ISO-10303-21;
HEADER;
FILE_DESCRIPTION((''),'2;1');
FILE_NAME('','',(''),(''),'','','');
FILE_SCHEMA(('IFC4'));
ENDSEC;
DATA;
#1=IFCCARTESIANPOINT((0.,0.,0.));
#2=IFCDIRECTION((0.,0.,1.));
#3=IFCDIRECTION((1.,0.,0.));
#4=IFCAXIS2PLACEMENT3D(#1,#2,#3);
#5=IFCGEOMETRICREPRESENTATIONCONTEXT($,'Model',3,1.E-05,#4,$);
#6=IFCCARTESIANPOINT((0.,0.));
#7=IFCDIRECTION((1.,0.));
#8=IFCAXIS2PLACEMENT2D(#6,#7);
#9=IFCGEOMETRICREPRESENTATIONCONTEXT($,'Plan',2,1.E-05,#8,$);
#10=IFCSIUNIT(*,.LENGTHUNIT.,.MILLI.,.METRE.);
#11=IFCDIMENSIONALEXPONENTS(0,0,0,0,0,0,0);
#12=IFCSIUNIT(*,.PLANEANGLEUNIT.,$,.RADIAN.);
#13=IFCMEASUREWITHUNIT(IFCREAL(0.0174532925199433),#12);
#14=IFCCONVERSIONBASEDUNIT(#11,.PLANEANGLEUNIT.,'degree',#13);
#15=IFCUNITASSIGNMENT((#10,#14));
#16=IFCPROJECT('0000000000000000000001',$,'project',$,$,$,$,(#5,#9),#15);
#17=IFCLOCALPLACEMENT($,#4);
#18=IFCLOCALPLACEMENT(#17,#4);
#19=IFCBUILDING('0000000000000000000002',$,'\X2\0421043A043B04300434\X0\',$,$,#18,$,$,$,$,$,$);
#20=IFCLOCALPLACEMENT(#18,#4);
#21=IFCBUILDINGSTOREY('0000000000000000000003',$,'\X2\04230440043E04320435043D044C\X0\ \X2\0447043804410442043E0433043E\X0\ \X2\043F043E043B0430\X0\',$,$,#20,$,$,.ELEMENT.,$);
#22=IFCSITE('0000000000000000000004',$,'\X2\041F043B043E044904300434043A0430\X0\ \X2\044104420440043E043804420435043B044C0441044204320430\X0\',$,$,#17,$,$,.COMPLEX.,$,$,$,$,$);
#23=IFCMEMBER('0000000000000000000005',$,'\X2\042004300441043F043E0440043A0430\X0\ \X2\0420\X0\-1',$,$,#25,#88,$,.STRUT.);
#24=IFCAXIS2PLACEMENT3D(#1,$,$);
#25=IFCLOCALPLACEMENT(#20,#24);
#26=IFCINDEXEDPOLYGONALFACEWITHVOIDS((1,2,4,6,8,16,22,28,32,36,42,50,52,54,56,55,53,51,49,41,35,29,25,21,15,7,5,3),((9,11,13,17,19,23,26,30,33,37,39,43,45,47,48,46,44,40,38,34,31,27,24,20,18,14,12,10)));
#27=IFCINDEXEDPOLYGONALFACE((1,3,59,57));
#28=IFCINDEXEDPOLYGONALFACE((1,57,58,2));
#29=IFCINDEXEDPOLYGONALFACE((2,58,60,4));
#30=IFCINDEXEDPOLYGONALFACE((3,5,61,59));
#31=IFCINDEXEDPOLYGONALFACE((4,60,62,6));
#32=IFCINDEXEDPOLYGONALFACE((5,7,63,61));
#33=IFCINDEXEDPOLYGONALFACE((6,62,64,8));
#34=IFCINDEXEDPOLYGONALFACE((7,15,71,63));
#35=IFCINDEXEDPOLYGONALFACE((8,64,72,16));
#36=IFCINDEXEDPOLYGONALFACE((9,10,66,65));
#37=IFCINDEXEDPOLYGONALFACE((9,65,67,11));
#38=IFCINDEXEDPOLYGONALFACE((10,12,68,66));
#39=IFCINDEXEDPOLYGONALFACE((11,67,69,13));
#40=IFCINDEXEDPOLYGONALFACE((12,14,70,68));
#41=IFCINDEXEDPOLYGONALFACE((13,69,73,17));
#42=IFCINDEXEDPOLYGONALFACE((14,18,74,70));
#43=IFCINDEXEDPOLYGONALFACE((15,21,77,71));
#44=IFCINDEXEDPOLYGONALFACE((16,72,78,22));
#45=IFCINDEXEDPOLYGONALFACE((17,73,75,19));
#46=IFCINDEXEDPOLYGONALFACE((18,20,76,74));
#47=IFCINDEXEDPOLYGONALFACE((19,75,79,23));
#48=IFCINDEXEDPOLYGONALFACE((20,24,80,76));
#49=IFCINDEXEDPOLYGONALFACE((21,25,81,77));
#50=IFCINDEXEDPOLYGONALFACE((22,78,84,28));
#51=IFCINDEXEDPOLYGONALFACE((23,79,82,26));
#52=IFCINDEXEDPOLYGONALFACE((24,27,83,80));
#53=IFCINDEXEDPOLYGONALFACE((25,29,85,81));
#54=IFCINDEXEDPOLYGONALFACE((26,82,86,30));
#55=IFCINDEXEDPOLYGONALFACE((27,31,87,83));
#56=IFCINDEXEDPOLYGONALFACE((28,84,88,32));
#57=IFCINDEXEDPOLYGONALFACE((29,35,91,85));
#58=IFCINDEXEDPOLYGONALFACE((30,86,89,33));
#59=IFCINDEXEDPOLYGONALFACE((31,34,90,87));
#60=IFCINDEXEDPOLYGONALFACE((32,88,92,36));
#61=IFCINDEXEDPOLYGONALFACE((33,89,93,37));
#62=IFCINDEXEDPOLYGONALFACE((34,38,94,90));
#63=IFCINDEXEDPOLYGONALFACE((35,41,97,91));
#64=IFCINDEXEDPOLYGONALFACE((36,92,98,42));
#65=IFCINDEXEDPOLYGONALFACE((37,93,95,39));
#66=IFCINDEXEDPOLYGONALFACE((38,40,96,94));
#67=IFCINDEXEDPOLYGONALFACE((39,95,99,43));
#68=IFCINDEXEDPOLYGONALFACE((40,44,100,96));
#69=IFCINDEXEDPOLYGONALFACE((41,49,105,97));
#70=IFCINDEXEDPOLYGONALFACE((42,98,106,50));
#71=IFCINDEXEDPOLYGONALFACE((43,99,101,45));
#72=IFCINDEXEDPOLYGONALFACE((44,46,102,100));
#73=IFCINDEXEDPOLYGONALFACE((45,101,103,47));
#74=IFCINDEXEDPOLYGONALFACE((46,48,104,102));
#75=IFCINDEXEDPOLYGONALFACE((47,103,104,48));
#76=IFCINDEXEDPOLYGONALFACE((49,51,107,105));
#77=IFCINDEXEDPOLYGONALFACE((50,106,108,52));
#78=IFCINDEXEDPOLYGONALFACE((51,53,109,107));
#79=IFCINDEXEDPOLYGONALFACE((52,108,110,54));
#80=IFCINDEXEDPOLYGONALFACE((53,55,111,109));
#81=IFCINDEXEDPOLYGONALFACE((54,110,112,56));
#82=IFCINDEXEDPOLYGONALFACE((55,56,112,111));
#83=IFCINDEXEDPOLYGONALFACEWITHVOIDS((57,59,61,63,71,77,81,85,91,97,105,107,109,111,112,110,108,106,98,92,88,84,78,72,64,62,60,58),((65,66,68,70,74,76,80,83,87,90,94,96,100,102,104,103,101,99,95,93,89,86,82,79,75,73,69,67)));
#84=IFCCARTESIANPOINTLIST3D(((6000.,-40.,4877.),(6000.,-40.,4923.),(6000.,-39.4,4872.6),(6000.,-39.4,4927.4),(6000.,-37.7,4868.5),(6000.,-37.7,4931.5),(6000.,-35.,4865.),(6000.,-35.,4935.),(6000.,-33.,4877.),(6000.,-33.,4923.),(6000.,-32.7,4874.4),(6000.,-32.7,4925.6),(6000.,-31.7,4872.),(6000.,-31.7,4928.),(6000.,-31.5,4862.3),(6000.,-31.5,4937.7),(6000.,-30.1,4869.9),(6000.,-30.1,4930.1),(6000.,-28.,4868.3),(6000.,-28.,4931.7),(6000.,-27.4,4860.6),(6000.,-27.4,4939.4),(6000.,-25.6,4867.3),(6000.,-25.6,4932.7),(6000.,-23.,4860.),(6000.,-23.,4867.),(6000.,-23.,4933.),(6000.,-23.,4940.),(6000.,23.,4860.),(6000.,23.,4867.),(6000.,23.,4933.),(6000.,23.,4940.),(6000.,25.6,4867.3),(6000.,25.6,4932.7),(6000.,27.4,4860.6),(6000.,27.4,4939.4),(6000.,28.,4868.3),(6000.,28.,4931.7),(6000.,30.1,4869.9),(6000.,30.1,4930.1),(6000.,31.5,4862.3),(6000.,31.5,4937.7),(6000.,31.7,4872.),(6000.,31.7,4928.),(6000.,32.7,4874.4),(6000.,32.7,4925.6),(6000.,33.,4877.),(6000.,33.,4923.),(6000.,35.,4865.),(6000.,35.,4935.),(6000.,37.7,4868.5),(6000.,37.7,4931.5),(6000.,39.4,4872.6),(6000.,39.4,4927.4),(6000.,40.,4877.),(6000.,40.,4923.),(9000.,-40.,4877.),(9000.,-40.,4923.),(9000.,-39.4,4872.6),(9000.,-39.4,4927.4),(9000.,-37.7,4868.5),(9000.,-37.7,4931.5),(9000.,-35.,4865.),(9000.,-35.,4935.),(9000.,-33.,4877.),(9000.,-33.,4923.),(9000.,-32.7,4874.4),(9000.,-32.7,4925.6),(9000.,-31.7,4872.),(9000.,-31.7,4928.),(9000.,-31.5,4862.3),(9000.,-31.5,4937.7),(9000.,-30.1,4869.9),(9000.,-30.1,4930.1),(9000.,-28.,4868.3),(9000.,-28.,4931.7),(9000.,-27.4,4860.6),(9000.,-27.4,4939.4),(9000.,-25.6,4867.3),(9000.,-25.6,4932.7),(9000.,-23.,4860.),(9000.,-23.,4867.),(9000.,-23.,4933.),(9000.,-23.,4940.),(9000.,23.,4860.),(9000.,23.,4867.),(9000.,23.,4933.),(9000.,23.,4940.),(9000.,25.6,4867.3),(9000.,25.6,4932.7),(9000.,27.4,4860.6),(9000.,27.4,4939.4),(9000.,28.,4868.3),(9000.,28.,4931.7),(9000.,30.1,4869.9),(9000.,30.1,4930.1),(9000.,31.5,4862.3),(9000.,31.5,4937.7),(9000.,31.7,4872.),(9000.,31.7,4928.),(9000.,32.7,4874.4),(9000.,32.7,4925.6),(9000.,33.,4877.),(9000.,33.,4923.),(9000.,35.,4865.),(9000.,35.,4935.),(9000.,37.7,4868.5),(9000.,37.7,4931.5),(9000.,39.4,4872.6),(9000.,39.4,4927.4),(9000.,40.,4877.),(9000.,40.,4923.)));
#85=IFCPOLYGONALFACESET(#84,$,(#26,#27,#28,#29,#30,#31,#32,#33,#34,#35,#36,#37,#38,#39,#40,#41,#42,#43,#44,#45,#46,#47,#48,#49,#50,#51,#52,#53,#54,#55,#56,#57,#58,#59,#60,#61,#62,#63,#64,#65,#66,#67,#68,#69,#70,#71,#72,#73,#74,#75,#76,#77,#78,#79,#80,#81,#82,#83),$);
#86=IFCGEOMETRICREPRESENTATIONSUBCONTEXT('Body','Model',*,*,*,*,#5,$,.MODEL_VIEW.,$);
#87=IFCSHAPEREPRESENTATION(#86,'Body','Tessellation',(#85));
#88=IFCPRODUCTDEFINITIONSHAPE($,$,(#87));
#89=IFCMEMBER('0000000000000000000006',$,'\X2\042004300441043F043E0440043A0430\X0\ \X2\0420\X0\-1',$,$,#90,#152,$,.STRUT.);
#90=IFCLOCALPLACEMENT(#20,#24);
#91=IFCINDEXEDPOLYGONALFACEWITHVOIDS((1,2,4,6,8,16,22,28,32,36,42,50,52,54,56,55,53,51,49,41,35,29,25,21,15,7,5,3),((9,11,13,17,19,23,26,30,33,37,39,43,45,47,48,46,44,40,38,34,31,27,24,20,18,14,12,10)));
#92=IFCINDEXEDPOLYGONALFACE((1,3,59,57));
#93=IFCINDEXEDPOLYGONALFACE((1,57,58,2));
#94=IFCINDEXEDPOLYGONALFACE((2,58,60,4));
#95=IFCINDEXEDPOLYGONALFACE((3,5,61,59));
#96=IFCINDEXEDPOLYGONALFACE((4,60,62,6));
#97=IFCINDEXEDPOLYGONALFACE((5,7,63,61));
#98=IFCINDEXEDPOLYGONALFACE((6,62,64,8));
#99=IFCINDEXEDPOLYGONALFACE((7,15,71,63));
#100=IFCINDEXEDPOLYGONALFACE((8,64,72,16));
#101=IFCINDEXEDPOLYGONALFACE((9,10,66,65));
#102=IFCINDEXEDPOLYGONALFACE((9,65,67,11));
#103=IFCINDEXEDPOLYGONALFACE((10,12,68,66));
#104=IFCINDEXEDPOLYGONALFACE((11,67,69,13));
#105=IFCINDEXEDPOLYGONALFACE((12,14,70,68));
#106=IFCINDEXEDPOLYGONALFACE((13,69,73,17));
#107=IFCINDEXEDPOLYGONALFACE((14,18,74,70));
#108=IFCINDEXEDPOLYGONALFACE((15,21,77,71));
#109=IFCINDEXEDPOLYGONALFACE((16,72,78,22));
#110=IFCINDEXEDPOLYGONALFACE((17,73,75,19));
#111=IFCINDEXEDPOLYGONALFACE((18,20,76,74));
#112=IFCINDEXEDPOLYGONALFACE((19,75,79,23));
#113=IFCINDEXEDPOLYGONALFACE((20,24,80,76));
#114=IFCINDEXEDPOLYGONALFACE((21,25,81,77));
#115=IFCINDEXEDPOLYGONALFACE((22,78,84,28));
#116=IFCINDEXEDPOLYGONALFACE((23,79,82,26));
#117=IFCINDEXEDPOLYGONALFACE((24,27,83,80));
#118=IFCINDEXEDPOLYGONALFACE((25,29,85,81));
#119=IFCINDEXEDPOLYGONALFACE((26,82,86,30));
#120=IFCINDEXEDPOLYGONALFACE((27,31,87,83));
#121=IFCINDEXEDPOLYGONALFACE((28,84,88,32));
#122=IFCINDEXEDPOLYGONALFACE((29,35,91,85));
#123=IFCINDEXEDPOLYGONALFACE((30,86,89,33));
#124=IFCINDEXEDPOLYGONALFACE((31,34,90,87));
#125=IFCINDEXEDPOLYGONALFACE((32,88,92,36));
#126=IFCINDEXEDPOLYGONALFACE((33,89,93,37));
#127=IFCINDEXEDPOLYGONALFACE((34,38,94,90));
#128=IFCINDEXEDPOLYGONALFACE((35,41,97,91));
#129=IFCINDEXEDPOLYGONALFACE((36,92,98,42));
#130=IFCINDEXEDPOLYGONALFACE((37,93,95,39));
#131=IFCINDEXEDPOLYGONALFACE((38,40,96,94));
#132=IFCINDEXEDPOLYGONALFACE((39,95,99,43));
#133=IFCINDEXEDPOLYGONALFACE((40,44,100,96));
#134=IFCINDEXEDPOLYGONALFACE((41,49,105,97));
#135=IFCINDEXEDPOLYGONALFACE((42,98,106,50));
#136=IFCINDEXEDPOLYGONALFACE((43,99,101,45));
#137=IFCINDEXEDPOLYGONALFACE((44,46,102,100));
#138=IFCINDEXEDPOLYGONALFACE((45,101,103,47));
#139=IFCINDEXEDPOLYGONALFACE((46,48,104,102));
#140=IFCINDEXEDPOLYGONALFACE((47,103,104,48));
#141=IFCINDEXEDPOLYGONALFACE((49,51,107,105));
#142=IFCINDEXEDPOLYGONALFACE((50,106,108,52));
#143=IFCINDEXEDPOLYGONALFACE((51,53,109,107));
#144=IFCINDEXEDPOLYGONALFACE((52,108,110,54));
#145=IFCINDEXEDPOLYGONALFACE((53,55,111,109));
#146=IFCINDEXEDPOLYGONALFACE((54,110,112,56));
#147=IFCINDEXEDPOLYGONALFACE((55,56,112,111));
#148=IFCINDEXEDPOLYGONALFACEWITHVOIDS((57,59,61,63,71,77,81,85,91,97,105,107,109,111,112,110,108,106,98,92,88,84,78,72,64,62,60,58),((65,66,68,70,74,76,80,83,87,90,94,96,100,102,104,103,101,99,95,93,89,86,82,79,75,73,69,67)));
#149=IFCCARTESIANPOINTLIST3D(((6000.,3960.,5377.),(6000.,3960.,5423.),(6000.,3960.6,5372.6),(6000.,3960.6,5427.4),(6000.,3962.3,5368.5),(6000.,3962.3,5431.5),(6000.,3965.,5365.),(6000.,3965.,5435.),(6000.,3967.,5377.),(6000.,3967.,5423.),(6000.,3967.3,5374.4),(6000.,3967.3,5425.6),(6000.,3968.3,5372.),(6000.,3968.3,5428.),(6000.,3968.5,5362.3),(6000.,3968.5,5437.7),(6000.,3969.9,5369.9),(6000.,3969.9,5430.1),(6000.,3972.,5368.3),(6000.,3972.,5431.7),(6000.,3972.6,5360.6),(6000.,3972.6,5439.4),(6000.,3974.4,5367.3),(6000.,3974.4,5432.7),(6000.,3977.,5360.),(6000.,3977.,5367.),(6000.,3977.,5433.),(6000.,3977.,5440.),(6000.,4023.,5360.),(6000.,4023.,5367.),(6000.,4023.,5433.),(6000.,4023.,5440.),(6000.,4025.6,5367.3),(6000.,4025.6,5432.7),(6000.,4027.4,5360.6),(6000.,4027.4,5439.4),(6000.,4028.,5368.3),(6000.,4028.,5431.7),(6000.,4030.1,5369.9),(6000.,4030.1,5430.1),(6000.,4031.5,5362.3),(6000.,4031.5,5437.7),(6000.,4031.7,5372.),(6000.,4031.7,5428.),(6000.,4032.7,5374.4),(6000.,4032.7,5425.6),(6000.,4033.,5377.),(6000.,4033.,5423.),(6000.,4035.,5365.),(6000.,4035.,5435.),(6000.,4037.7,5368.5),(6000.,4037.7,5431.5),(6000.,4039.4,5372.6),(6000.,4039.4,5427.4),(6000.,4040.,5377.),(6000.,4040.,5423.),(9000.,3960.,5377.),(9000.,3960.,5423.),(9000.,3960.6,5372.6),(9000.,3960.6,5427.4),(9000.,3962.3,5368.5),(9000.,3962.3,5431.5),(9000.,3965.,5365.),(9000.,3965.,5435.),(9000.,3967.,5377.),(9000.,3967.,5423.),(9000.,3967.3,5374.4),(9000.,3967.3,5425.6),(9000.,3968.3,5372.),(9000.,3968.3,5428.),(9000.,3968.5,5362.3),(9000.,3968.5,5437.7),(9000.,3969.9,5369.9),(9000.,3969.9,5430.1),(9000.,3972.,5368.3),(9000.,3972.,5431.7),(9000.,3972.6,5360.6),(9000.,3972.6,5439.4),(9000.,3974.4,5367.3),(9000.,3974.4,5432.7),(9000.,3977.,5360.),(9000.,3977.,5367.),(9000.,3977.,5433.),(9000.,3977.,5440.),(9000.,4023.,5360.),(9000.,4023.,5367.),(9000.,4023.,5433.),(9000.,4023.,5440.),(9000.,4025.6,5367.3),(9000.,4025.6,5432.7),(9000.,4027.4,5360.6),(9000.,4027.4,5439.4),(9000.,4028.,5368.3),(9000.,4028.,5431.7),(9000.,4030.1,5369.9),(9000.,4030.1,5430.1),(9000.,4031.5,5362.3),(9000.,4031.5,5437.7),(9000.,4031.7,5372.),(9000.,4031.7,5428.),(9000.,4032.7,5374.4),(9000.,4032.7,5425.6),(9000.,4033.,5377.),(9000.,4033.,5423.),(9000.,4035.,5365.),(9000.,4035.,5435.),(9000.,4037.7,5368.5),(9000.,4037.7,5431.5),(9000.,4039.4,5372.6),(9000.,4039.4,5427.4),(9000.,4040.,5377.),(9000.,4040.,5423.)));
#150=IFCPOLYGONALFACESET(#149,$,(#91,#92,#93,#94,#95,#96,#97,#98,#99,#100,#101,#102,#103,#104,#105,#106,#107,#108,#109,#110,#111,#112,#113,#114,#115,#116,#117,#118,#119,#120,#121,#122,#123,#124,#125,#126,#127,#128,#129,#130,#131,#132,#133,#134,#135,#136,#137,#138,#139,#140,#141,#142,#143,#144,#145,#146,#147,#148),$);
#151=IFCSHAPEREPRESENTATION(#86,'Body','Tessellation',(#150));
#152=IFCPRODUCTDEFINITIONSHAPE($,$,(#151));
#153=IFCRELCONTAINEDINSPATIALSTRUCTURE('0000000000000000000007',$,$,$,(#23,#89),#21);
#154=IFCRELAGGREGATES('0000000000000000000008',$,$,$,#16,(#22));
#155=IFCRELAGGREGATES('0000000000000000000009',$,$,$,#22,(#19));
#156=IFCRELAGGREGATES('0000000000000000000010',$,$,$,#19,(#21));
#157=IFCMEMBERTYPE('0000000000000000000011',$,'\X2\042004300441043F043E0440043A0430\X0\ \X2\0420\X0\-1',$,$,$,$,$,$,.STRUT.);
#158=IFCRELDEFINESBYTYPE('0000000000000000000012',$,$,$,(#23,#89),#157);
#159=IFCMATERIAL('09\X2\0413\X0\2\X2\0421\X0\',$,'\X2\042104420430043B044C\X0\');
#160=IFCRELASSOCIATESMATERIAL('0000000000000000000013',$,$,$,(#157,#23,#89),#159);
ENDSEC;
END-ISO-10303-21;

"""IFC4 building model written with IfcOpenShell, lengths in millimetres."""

from ifc_helpers import new_model, entity, si_unit, converted_unit, frame, origin_with_axes, origin_2d_with_axis, place, context, subcontext, project, spatial, hollow_rectangle, extrude, material, material_profile, profile_set, profile_usage, type_object, element, save


model = new_model("IFC4")

# Units and contexts
model_context = context("Model", 3, precision=1e-05, world=origin_with_axes())
plan_context = context("Plan", 2, precision=1e-05, world=origin_2d_with_axis())
body_context = subcontext(model_context, "Body", "Model", "MODEL_VIEW")
ifc_project = project(units=[si_unit("LENGTHUNIT", "METRE", prefix="MILLI"), converted_unit("PLANEANGLEUNIT", "degree", entity("IfcReal", 0.0174532925199433), si_unit("PLANEANGLEUNIT", "RADIAN"), dimensions=[0, 0, 0, 0, 0, 0, 0])], contexts=[model_context, plan_context])

# Site, building, storey
site_placement = place(None, origin_with_axes())
site = spatial("IfcSite", under=ifc_project, at=site_placement, Name="Площадка строительства", CompositionType="COMPLEX")
building_placement = place(site_placement, origin_with_axes())
building = spatial("IfcBuilding", under=site, at=building_placement, Name="Склад")
storey_placement = place(building_placement, origin_with_axes())
storey = spatial("IfcBuildingStorey", under=building, at=storey_placement, Name="Уровень чистого пола", CompositionType="ELEMENT")

# Members
ifc_material_1 = material(Name="09Г2С", Category="Сталь")
ifc_material_profile_1 = material_profile(ifc_material_1, hollow_rectangle(XDim=80.0, YDim=80.0, WallThickness=7.0, InnerFilletRadius=10.0, OuterFilletRadius=17.0))
ifc_profile_set_1 = profile_set([ifc_material_profile_1], Name="PK80x7_09G2S")
ifc_profile_usage_1 = profile_usage(ifc_profile_set_1, cardinal=5)
member_type_1 = type_object("IfcMemberType", Name="Распорка Р-1", PredefinedType="STRUT", material=ifc_profile_set_1)
for number, where, z_axis, x_axis, name in (
    (1, (6000.0, 0.0, 4900.0), (1.0, 0.0, 0.0), (0.0, 1.0, 0.0), "Распорка Р-1"),
    (2, (6000.0, 4000.0, 5400.0), (1.0, 0.0, 0.0), (0.0, 1.0, 0.0), "Распорка Р-1"),
):
    element("IfcMember", number, at=place(storey_placement, frame(where, z_axis=z_axis, x_axis=x_axis)), inside=storey, type_object=member_type_1, material=ifc_profile_usage_1, Name=name, PredefinedType="STRUT", context=body_context, shape_type="SweptSolid", body=[
        extrude(hollow_rectangle(XDim=80.0, YDim=80.0, WallThickness=7.0, InnerFilletRadius=10.0, OuterFilletRadius=17.0), origin_with_axes(), (0.0, 0.0, 1.0), 3000.0),
    ])

save(model, "model.ifc")
